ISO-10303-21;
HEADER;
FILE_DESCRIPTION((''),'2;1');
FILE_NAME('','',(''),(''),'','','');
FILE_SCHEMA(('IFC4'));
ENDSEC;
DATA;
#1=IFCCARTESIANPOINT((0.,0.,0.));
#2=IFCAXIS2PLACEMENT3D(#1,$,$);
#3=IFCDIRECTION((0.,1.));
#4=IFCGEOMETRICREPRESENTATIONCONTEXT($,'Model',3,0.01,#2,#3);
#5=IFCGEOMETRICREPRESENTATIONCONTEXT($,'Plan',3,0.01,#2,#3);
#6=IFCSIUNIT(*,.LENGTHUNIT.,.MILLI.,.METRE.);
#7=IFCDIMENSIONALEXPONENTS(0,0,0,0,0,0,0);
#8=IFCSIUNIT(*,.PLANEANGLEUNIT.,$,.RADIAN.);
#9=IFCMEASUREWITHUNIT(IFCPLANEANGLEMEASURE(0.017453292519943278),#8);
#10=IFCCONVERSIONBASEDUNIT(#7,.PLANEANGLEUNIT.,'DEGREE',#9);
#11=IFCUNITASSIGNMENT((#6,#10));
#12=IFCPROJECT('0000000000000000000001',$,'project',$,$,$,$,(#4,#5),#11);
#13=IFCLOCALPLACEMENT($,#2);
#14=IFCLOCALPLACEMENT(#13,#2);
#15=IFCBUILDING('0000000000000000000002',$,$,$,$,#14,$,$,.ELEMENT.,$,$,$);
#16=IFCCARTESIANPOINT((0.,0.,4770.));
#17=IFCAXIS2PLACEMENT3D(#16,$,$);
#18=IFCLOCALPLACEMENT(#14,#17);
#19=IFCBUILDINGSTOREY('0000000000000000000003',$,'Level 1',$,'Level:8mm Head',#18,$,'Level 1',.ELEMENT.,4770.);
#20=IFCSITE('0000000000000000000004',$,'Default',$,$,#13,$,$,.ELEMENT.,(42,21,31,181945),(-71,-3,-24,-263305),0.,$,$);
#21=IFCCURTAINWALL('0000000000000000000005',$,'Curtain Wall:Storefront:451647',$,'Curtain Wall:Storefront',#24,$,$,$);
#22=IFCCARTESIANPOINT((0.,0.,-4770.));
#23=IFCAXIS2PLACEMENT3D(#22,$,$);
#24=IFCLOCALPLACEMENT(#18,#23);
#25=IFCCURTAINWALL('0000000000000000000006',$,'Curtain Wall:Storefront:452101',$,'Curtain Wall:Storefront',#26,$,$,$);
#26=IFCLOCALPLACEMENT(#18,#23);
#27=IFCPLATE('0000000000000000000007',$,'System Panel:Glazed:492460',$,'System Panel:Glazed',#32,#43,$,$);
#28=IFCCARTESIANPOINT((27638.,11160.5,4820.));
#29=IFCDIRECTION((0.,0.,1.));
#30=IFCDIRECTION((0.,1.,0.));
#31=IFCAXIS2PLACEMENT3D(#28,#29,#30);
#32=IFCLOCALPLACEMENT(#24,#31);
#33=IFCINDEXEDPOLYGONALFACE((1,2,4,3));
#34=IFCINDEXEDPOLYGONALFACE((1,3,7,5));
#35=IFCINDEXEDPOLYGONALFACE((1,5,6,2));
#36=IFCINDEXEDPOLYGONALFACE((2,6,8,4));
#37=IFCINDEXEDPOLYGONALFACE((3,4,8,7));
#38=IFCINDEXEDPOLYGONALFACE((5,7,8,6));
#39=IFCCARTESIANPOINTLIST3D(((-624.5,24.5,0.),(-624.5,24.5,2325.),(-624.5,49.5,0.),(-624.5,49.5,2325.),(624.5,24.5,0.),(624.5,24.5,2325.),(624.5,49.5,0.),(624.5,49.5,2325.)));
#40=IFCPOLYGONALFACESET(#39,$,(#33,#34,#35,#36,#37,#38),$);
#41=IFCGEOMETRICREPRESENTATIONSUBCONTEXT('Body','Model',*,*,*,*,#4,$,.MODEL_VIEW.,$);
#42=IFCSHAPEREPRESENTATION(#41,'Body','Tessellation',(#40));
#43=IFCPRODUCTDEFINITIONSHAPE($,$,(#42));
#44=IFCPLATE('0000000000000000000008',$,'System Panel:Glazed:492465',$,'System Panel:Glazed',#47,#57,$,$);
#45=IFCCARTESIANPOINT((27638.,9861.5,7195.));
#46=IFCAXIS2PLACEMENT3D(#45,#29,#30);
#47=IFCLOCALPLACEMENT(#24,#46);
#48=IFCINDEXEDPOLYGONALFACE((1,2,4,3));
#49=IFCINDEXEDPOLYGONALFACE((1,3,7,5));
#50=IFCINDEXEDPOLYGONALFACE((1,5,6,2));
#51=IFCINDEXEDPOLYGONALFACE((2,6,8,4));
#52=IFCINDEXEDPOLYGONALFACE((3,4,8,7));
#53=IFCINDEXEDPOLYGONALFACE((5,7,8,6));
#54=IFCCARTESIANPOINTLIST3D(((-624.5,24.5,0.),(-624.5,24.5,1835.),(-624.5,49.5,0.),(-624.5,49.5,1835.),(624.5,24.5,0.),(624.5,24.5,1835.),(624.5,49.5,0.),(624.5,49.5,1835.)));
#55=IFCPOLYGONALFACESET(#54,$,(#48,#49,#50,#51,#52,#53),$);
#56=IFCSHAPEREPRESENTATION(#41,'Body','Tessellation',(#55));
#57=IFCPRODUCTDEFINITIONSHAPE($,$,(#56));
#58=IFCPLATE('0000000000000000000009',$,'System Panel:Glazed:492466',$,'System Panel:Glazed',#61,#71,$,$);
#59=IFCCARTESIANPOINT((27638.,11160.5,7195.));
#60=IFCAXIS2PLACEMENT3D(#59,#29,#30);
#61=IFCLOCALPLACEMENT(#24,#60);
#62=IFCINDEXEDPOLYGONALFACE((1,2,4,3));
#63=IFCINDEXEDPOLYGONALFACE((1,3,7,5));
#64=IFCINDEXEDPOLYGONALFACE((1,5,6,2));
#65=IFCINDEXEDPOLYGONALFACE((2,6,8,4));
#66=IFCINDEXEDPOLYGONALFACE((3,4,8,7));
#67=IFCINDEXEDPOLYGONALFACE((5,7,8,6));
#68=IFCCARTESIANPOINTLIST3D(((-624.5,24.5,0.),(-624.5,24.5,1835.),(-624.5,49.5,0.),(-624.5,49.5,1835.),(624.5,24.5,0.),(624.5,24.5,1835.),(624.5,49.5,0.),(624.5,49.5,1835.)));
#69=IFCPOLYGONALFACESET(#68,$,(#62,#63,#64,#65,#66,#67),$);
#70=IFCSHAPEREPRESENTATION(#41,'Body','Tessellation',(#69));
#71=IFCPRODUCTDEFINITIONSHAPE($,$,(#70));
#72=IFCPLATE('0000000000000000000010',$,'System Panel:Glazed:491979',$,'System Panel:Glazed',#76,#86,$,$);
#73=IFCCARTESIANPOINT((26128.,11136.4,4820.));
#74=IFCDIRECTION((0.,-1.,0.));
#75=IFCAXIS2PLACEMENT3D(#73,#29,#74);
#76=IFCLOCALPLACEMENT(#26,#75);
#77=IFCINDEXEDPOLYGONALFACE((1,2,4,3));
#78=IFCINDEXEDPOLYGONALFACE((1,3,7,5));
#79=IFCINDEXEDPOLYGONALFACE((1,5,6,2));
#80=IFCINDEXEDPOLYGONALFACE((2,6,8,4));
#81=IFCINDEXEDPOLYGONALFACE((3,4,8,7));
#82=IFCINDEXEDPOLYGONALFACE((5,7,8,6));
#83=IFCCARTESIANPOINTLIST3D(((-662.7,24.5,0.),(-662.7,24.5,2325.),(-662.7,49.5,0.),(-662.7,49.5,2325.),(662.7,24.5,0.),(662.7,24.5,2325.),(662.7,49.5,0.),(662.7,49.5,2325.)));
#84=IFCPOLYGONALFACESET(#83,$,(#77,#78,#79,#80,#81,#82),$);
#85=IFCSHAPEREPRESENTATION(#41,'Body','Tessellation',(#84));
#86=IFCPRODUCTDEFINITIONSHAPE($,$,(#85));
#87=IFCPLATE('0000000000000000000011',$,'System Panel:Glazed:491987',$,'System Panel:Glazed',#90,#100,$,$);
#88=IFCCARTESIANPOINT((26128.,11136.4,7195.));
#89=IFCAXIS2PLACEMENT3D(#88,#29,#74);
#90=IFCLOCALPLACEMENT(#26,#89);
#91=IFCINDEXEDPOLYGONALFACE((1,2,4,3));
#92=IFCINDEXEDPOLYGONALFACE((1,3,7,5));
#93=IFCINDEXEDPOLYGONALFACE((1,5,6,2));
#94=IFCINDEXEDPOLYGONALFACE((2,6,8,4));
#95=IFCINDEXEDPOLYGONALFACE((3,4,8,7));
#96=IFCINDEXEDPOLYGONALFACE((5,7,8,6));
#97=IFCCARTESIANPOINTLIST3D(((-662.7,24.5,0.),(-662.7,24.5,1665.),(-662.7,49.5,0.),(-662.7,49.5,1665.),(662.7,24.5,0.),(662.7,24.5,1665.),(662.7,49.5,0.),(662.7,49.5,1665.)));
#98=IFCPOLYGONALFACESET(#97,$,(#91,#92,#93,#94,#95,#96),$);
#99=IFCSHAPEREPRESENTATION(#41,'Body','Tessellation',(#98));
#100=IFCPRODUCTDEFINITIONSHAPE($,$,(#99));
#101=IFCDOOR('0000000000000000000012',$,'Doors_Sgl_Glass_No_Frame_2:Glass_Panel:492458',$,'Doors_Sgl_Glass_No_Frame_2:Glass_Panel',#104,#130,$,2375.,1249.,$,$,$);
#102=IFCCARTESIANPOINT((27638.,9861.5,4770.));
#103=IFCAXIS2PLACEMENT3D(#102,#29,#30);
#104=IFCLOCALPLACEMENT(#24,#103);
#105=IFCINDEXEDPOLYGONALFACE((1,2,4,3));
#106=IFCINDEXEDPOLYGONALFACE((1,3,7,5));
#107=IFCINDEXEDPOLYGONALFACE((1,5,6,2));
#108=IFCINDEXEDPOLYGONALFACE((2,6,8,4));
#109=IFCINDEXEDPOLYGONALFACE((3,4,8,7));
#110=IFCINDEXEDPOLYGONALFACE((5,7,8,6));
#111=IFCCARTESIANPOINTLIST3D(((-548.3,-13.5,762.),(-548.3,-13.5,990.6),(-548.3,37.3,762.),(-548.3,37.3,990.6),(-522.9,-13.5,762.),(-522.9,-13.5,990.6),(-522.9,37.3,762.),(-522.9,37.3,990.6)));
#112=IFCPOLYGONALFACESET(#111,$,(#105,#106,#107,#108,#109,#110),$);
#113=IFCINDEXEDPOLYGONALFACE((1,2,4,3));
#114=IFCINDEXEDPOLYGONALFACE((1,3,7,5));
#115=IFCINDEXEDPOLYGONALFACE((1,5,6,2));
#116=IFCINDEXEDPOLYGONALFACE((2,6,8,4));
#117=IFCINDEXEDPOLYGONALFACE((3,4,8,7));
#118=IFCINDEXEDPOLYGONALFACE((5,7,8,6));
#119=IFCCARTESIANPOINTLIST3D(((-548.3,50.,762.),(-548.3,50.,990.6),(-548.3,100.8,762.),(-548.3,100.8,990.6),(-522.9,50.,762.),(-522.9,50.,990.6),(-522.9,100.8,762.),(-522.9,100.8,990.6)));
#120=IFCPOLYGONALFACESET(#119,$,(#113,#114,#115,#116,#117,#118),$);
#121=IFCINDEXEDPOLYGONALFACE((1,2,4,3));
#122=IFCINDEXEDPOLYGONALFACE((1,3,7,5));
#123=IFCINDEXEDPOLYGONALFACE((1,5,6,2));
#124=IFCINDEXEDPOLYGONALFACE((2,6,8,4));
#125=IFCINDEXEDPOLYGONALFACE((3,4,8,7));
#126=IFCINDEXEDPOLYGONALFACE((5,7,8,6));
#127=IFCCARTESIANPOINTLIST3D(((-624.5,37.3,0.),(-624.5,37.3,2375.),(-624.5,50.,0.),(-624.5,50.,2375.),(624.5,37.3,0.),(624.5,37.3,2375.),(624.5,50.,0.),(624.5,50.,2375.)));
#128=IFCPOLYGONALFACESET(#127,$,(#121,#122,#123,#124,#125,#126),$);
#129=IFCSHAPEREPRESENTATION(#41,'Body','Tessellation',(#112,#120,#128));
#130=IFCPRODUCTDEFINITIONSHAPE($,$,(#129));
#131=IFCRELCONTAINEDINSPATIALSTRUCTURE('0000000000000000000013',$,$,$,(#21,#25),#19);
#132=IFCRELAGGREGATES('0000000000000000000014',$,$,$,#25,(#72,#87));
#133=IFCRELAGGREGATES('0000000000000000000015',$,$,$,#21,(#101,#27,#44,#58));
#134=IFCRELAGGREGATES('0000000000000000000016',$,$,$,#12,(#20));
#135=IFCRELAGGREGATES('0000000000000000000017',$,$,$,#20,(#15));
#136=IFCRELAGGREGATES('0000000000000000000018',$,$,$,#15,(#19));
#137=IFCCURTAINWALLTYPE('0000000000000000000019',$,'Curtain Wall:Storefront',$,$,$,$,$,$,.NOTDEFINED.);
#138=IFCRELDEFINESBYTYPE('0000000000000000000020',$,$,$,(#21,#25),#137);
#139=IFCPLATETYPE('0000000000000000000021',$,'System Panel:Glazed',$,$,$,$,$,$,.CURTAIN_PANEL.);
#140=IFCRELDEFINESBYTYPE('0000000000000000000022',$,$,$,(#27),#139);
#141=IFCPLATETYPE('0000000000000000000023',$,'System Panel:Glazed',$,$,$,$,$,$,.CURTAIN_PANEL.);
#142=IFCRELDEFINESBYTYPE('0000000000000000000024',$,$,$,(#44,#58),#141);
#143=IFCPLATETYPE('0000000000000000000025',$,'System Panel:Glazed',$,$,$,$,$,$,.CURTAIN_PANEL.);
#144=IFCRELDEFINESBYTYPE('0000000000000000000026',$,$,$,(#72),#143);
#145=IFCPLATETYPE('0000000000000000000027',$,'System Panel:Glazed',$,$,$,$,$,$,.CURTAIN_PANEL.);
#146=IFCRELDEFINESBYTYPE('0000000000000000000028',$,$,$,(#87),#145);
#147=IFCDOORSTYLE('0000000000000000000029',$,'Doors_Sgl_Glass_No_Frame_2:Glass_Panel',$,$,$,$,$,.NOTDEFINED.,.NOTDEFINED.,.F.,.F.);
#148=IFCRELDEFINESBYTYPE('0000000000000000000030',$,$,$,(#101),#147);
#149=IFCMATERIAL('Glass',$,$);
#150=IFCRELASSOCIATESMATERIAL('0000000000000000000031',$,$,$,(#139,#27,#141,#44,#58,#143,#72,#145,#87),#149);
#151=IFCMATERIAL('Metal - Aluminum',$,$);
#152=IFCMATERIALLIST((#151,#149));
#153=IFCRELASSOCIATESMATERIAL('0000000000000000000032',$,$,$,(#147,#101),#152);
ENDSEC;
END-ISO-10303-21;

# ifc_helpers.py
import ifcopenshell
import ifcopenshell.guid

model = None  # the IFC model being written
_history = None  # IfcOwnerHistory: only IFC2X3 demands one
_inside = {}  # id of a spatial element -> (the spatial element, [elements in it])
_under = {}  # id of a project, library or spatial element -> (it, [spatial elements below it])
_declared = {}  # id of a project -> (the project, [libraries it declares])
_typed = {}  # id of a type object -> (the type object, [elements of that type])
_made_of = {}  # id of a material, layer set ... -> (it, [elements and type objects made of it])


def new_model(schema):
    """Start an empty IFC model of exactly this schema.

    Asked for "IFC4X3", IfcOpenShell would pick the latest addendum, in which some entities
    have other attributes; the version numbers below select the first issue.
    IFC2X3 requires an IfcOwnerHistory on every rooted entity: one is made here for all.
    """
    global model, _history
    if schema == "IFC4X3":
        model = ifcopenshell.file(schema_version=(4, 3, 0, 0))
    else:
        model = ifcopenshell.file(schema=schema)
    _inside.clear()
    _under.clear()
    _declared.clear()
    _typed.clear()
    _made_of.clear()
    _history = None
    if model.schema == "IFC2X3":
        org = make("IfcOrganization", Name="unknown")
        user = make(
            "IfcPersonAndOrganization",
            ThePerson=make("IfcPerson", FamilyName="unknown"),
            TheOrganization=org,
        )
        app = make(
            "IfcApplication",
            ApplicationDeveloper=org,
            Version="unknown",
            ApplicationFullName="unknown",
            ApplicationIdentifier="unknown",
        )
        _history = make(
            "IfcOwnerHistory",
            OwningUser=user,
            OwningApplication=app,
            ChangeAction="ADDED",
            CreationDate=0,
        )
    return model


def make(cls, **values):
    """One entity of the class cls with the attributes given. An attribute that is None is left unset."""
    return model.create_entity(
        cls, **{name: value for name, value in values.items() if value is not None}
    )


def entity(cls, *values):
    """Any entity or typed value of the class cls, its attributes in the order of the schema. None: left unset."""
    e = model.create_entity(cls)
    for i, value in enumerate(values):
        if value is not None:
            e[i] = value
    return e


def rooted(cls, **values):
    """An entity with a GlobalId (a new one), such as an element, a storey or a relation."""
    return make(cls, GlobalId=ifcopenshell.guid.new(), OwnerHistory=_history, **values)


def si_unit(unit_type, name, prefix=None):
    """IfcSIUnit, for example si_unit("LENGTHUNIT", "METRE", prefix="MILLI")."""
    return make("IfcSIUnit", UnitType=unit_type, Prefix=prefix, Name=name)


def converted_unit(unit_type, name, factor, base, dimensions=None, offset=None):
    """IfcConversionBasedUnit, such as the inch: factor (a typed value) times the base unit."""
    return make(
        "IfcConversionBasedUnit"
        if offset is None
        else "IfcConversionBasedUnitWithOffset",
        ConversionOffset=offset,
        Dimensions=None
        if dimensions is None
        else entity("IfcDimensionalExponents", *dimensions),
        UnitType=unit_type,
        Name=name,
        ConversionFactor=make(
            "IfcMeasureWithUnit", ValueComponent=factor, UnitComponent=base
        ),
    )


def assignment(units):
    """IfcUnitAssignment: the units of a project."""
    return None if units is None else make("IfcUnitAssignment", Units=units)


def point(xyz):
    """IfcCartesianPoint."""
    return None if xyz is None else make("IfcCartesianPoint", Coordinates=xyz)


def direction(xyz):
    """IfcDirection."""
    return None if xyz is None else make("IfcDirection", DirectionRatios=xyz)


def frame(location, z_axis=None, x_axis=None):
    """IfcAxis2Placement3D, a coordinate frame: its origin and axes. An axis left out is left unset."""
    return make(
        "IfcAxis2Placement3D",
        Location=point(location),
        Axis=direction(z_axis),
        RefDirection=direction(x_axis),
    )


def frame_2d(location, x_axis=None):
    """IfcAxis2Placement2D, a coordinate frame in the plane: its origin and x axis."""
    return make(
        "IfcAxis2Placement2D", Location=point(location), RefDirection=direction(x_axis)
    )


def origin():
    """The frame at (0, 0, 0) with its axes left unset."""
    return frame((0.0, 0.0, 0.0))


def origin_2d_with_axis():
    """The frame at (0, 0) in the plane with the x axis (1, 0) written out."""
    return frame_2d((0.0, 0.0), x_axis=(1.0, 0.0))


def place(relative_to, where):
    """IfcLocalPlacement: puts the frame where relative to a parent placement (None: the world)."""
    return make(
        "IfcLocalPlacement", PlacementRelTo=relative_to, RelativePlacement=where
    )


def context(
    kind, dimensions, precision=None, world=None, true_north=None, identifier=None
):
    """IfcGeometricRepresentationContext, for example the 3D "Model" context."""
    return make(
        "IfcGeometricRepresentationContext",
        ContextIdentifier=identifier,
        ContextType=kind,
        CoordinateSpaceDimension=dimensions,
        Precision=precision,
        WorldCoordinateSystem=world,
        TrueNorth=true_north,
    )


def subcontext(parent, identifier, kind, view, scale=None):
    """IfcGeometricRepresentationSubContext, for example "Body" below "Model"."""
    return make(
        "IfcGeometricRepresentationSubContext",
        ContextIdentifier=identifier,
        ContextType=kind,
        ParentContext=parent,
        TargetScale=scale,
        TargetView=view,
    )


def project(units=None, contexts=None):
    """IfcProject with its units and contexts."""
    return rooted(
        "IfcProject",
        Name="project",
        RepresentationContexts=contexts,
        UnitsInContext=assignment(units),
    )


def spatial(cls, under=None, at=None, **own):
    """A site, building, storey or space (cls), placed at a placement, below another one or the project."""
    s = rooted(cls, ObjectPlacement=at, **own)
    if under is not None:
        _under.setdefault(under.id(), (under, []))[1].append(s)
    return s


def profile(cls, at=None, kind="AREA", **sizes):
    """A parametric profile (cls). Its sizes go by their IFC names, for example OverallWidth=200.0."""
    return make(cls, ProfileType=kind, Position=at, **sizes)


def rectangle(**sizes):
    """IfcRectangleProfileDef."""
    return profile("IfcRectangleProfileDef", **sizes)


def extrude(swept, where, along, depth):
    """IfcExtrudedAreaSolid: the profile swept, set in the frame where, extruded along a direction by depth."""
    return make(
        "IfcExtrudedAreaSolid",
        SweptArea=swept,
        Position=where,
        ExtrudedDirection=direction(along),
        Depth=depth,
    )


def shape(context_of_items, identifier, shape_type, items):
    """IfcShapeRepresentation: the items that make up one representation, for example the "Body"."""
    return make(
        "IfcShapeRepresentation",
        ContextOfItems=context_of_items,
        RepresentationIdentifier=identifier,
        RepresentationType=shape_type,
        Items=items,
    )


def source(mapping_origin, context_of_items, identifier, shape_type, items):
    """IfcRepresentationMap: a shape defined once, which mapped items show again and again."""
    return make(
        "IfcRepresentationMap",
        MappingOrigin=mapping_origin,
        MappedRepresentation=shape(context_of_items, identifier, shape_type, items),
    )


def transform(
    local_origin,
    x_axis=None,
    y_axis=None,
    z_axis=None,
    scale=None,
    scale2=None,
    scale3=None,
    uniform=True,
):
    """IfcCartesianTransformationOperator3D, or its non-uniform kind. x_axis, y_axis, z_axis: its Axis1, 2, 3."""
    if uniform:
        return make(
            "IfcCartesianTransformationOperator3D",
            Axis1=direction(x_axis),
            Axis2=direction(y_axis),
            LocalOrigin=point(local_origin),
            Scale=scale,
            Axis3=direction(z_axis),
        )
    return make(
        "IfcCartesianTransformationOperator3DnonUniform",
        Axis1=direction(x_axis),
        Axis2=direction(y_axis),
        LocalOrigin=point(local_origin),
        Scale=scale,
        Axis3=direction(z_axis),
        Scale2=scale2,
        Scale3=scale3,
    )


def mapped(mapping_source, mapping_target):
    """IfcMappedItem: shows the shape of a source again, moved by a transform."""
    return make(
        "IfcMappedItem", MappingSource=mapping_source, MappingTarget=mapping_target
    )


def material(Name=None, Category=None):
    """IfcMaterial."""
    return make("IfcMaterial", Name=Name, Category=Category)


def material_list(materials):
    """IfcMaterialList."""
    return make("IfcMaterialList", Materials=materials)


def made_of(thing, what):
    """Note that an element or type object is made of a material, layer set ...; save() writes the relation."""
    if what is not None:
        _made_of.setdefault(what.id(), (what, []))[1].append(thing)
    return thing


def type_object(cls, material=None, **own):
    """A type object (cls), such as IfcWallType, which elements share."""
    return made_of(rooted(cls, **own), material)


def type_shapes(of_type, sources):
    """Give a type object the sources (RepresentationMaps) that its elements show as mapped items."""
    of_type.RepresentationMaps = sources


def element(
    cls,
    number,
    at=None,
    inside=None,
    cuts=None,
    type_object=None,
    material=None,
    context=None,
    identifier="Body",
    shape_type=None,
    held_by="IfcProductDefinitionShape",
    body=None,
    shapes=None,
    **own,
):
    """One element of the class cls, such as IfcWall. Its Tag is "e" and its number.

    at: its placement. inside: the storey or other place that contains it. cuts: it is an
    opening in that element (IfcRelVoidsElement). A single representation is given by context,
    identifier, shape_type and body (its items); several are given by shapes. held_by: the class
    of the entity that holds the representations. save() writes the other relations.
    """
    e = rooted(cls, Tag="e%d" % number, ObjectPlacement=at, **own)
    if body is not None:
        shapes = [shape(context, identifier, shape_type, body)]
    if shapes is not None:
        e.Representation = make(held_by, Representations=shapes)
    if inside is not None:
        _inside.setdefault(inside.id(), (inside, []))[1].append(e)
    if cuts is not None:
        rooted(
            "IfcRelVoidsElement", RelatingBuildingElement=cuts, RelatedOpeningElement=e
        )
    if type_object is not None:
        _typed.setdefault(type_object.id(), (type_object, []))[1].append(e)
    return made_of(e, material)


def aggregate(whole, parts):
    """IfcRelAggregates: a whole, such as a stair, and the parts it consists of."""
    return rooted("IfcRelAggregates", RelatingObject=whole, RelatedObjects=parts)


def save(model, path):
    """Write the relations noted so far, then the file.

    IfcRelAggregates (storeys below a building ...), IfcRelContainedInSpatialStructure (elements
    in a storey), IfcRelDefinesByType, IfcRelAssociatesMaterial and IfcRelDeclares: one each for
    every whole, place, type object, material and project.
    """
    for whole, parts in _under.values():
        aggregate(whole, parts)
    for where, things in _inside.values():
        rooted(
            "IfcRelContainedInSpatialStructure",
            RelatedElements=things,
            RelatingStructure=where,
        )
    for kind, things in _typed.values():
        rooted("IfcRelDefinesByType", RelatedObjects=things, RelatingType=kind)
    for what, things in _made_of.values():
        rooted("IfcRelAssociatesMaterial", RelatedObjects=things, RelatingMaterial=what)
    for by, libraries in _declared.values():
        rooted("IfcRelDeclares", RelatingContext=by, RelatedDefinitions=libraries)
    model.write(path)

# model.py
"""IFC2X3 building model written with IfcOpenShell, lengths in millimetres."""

from ifc_helpers import new_model, entity, si_unit, converted_unit, direction, frame, frame_2d, origin, origin_2d_with_axis, place, context, subcontext, project, spatial, rectangle, extrude, source, transform, mapped, material, material_list, type_object, type_shapes, element, aggregate, save


model = new_model("IFC2X3")

# Units and contexts
model_context = context("Model", 3, precision=0.01, world=origin(), true_north=direction((0.0, 1.0)))
plan_context = context("Plan", 3, precision=0.01, world=origin(), true_north=direction((0.0, 1.0)))
body_context = subcontext(model_context, "Body", "Model", "MODEL_VIEW")
ifc_project = project(units=[si_unit("LENGTHUNIT", "METRE", prefix="MILLI"), converted_unit("PLANEANGLEUNIT", "DEGREE", entity("IfcPlaneAngleMeasure", 0.017453292519943278), si_unit("PLANEANGLEUNIT", "RADIAN"), dimensions=[0, 0, 0, 0, 0, 0, 0])], contexts=[model_context, plan_context])

# Site, building, storey
site_placement = place(None, origin())
site = spatial("IfcSite", under=ifc_project, at=site_placement, Name="Default", CompositionType="ELEMENT", RefLatitude=(42, 21, 31, 181945), RefLongitude=(-71, -3, -24, -263305), RefElevation=0.0)
building_placement = place(site_placement, origin())
building = spatial("IfcBuilding", under=site, at=building_placement, CompositionType="ELEMENT")
storey_placement = place(building_placement, frame((0.0, 0.0, 4770.0)))
storey = spatial("IfcBuildingStorey", under=building, at=storey_placement, Name="Level 1", ObjectType="Level:8mm Head", LongName="Level 1", CompositionType="ELEMENT", Elevation=4770.0)

# Curtain walls
curtain_wall_type = type_object("IfcCurtainWallType", Name="Curtain Wall:Storefront", PredefinedType="NOTDEFINED")
curtain_wall_1_placement = place(storey_placement, frame((0.0, 0.0, -4770.0)))
curtain_wall_1 = element("IfcCurtainWall", 1, at=curtain_wall_1_placement, inside=storey, type_object=curtain_wall_type, Name="Curtain Wall:Storefront:451647", ObjectType="Curtain Wall:Storefront")
curtain_wall_2_placement = place(storey_placement, frame((0.0, 0.0, -4770.0)))
curtain_wall_2 = element("IfcCurtainWall", 2, at=curtain_wall_2_placement, inside=storey, type_object=curtain_wall_type, Name="Curtain Wall:Storefront:452101", ObjectType="Curtain Wall:Storefront")

# Plates
ifc_material_1 = material(Name="Glass")
plate_type_1 = type_object("IfcPlateType", Name="System Panel:Glazed", PredefinedType="CURTAIN_PANEL", material=ifc_material_1)
shared_shape_1 = source(origin(), body_context, "Body", "SweptSolid", [
    extrude(rectangle(XDim=25.0, YDim=1249.0, at=origin_2d_with_axis()), frame((0.0, 37.0, 0.0), z_axis=(0.0, 0.0, 1.0), x_axis=(0.0, 1.0, 0.0)), (0.0, 0.0, 1.0), 2325.0),
])
type_shapes(plate_type_1, [shared_shape_1])
plate_1_placement = place(curtain_wall_1_placement, frame((27638.0, 11160.5, 4820.0), z_axis=(0.0, 0.0, 1.0), x_axis=(0.0, 1.0, 0.0)))
plate_1 = element("IfcPlate", 3, at=plate_1_placement, type_object=plate_type_1, material=ifc_material_1, Name="System Panel:Glazed:492460", ObjectType="System Panel:Glazed", context=body_context, shape_type="MappedRepresentation", body=[
    mapped(shared_shape_1, transform((0.0, 0.0, 0.0), scale=1.0)),
])
plate_type_2 = type_object("IfcPlateType", Name="System Panel:Glazed", PredefinedType="CURTAIN_PANEL", material=ifc_material_1)
shared_shape_2 = source(origin(), body_context, "Body", "SweptSolid", [
    extrude(rectangle(XDim=25.0, YDim=1249.0, at=origin_2d_with_axis()), frame((0.0, 37.0, 0.0), z_axis=(0.0, 0.0, 1.0), x_axis=(0.0, 1.0, 0.0)), (0.0, 0.0, 1.0), 1835.0),
])
type_shapes(plate_type_2, [shared_shape_2])
plate_2_placement = place(curtain_wall_1_placement, frame((27638.0, 9861.5, 7195.0), z_axis=(0.0, 0.0, 1.0), x_axis=(0.0, 1.0, 0.0)))
plate_2 = element("IfcPlate", 4, at=plate_2_placement, type_object=plate_type_2, material=ifc_material_1, Name="System Panel:Glazed:492465", ObjectType="System Panel:Glazed", context=body_context, shape_type="MappedRepresentation", body=[
    mapped(shared_shape_2, transform((0.0, 0.0, 0.0), scale=1.0)),
])
plate_3_placement = place(curtain_wall_1_placement, frame((27638.0, 11160.5, 7195.0), z_axis=(0.0, 0.0, 1.0), x_axis=(0.0, 1.0, 0.0)))
plate_3 = element("IfcPlate", 5, at=plate_3_placement, type_object=plate_type_2, material=ifc_material_1, Name="System Panel:Glazed:492466", ObjectType="System Panel:Glazed", context=body_context, shape_type="MappedRepresentation", body=[
    mapped(shared_shape_2, transform((0.0, 0.0, 0.0), scale=1.0)),
])
plate_type_3 = type_object("IfcPlateType", Name="System Panel:Glazed", PredefinedType="CURTAIN_PANEL", material=ifc_material_1)
shared_shape_3 = source(origin(), body_context, "Body", "SweptSolid", [
    extrude(rectangle(XDim=25.0, YDim=1325.4, at=origin_2d_with_axis()), frame((0.0, 37.0, 0.0), z_axis=(0.0, 0.0, 1.0), x_axis=(0.0, 1.0, 0.0)), (0.0, 0.0, 1.0), 2325.0),
])
type_shapes(plate_type_3, [shared_shape_3])
plate_4_placement = place(curtain_wall_2_placement, frame((26128.0, 11136.4, 4820.0), z_axis=(0.0, 0.0, 1.0), x_axis=(0.0, -1.0, 0.0)))
plate_4 = element("IfcPlate", 6, at=plate_4_placement, type_object=plate_type_3, material=ifc_material_1, Name="System Panel:Glazed:491979", ObjectType="System Panel:Glazed", context=body_context, shape_type="MappedRepresentation", body=[
    mapped(shared_shape_3, transform((0.0, 0.0, 0.0), scale=1.0)),
])
plate_type_4 = type_object("IfcPlateType", Name="System Panel:Glazed", PredefinedType="CURTAIN_PANEL", material=ifc_material_1)
shared_shape_4 = source(origin(), body_context, "Body", "SweptSolid", [
    extrude(rectangle(XDim=25.0, YDim=1325.4, at=origin_2d_with_axis()), frame((0.0, 37.0, 0.0), z_axis=(0.0, 0.0, 1.0), x_axis=(0.0, 1.0, 0.0)), (0.0, 0.0, 1.0), 1665.0),
])
type_shapes(plate_type_4, [shared_shape_4])
plate_5_placement = place(curtain_wall_2_placement, frame((26128.0, 11136.4, 7195.0), z_axis=(0.0, 0.0, 1.0), x_axis=(0.0, -1.0, 0.0)))
plate_5 = element("IfcPlate", 7, at=plate_5_placement, type_object=plate_type_4, material=ifc_material_1, Name="System Panel:Glazed:491987", ObjectType="System Panel:Glazed", context=body_context, shape_type="MappedRepresentation", body=[
    mapped(shared_shape_4, transform((0.0, 0.0, 0.0), scale=1.0)),
])
aggregate(curtain_wall_2, [plate_4, plate_5])

# Door
ifc_material_2 = material(Name="Metal - Aluminum")
ifc_material_list = material_list([ifc_material_2, ifc_material_1])
door_style = type_object("IfcDoorStyle", Name="Doors_Sgl_Glass_No_Frame_2:Glass_Panel", ConstructionType="NOTDEFINED", OperationType="NOTDEFINED", ParameterTakesPrecedence=False, Sizeable=False, material=ifc_material_list)
shared_shape_5 = source(origin(), body_context, "Body", "SweptSolid", [
    extrude(rectangle(XDim=50.8, YDim=25.4, at=origin_2d_with_axis()), frame((-535.6, 11.9, 762.0), z_axis=(0.0, 0.0, 1.0), x_axis=(0.0, 1.0, 0.0)), (0.0, 0.0, 1.0), 228.6),
    extrude(rectangle(XDim=50.8, YDim=25.4, at=frame_2d((0.0, 0.0), x_axis=(1.0, 0.0))), frame((-535.6, 75.4, 762.0), z_axis=(0.0, 0.0, 1.0), x_axis=(0.0, -1.0, 0.0)), (0.0, 0.0, 1.0), 228.6),
    extrude(rectangle(XDim=1249.0, YDim=12.7, at=frame_2d((0.0, 0.0), x_axis=(1.0, 0.0))), frame((0.0, 43.7, 0.0), z_axis=(0.0, 0.0, 1.0), x_axis=(-1.0, 0.0, 0.0)), (0.0, 0.0, 1.0), 2375.0),
])
type_shapes(door_style, [shared_shape_5])
door_placement = place(curtain_wall_1_placement, frame((27638.0, 9861.5, 4770.0), z_axis=(0.0, 0.0, 1.0), x_axis=(0.0, 1.0, 0.0)))
door = element("IfcDoor", 8, at=door_placement, type_object=door_style, material=ifc_material_list, Name="Doors_Sgl_Glass_No_Frame_2:Glass_Panel:492458", ObjectType="Doors_Sgl_Glass_No_Frame_2:Glass_Panel", OverallHeight=2375.0, OverallWidth=1249.0, context=body_context, shape_type="MappedRepresentation", body=[
    mapped(shared_shape_5, transform((0.0, 0.0, 0.0), scale=1.0)),
])
aggregate(curtain_wall_1, [door, plate_1, plate_2, plate_3])

save(model, "model.ifc")
